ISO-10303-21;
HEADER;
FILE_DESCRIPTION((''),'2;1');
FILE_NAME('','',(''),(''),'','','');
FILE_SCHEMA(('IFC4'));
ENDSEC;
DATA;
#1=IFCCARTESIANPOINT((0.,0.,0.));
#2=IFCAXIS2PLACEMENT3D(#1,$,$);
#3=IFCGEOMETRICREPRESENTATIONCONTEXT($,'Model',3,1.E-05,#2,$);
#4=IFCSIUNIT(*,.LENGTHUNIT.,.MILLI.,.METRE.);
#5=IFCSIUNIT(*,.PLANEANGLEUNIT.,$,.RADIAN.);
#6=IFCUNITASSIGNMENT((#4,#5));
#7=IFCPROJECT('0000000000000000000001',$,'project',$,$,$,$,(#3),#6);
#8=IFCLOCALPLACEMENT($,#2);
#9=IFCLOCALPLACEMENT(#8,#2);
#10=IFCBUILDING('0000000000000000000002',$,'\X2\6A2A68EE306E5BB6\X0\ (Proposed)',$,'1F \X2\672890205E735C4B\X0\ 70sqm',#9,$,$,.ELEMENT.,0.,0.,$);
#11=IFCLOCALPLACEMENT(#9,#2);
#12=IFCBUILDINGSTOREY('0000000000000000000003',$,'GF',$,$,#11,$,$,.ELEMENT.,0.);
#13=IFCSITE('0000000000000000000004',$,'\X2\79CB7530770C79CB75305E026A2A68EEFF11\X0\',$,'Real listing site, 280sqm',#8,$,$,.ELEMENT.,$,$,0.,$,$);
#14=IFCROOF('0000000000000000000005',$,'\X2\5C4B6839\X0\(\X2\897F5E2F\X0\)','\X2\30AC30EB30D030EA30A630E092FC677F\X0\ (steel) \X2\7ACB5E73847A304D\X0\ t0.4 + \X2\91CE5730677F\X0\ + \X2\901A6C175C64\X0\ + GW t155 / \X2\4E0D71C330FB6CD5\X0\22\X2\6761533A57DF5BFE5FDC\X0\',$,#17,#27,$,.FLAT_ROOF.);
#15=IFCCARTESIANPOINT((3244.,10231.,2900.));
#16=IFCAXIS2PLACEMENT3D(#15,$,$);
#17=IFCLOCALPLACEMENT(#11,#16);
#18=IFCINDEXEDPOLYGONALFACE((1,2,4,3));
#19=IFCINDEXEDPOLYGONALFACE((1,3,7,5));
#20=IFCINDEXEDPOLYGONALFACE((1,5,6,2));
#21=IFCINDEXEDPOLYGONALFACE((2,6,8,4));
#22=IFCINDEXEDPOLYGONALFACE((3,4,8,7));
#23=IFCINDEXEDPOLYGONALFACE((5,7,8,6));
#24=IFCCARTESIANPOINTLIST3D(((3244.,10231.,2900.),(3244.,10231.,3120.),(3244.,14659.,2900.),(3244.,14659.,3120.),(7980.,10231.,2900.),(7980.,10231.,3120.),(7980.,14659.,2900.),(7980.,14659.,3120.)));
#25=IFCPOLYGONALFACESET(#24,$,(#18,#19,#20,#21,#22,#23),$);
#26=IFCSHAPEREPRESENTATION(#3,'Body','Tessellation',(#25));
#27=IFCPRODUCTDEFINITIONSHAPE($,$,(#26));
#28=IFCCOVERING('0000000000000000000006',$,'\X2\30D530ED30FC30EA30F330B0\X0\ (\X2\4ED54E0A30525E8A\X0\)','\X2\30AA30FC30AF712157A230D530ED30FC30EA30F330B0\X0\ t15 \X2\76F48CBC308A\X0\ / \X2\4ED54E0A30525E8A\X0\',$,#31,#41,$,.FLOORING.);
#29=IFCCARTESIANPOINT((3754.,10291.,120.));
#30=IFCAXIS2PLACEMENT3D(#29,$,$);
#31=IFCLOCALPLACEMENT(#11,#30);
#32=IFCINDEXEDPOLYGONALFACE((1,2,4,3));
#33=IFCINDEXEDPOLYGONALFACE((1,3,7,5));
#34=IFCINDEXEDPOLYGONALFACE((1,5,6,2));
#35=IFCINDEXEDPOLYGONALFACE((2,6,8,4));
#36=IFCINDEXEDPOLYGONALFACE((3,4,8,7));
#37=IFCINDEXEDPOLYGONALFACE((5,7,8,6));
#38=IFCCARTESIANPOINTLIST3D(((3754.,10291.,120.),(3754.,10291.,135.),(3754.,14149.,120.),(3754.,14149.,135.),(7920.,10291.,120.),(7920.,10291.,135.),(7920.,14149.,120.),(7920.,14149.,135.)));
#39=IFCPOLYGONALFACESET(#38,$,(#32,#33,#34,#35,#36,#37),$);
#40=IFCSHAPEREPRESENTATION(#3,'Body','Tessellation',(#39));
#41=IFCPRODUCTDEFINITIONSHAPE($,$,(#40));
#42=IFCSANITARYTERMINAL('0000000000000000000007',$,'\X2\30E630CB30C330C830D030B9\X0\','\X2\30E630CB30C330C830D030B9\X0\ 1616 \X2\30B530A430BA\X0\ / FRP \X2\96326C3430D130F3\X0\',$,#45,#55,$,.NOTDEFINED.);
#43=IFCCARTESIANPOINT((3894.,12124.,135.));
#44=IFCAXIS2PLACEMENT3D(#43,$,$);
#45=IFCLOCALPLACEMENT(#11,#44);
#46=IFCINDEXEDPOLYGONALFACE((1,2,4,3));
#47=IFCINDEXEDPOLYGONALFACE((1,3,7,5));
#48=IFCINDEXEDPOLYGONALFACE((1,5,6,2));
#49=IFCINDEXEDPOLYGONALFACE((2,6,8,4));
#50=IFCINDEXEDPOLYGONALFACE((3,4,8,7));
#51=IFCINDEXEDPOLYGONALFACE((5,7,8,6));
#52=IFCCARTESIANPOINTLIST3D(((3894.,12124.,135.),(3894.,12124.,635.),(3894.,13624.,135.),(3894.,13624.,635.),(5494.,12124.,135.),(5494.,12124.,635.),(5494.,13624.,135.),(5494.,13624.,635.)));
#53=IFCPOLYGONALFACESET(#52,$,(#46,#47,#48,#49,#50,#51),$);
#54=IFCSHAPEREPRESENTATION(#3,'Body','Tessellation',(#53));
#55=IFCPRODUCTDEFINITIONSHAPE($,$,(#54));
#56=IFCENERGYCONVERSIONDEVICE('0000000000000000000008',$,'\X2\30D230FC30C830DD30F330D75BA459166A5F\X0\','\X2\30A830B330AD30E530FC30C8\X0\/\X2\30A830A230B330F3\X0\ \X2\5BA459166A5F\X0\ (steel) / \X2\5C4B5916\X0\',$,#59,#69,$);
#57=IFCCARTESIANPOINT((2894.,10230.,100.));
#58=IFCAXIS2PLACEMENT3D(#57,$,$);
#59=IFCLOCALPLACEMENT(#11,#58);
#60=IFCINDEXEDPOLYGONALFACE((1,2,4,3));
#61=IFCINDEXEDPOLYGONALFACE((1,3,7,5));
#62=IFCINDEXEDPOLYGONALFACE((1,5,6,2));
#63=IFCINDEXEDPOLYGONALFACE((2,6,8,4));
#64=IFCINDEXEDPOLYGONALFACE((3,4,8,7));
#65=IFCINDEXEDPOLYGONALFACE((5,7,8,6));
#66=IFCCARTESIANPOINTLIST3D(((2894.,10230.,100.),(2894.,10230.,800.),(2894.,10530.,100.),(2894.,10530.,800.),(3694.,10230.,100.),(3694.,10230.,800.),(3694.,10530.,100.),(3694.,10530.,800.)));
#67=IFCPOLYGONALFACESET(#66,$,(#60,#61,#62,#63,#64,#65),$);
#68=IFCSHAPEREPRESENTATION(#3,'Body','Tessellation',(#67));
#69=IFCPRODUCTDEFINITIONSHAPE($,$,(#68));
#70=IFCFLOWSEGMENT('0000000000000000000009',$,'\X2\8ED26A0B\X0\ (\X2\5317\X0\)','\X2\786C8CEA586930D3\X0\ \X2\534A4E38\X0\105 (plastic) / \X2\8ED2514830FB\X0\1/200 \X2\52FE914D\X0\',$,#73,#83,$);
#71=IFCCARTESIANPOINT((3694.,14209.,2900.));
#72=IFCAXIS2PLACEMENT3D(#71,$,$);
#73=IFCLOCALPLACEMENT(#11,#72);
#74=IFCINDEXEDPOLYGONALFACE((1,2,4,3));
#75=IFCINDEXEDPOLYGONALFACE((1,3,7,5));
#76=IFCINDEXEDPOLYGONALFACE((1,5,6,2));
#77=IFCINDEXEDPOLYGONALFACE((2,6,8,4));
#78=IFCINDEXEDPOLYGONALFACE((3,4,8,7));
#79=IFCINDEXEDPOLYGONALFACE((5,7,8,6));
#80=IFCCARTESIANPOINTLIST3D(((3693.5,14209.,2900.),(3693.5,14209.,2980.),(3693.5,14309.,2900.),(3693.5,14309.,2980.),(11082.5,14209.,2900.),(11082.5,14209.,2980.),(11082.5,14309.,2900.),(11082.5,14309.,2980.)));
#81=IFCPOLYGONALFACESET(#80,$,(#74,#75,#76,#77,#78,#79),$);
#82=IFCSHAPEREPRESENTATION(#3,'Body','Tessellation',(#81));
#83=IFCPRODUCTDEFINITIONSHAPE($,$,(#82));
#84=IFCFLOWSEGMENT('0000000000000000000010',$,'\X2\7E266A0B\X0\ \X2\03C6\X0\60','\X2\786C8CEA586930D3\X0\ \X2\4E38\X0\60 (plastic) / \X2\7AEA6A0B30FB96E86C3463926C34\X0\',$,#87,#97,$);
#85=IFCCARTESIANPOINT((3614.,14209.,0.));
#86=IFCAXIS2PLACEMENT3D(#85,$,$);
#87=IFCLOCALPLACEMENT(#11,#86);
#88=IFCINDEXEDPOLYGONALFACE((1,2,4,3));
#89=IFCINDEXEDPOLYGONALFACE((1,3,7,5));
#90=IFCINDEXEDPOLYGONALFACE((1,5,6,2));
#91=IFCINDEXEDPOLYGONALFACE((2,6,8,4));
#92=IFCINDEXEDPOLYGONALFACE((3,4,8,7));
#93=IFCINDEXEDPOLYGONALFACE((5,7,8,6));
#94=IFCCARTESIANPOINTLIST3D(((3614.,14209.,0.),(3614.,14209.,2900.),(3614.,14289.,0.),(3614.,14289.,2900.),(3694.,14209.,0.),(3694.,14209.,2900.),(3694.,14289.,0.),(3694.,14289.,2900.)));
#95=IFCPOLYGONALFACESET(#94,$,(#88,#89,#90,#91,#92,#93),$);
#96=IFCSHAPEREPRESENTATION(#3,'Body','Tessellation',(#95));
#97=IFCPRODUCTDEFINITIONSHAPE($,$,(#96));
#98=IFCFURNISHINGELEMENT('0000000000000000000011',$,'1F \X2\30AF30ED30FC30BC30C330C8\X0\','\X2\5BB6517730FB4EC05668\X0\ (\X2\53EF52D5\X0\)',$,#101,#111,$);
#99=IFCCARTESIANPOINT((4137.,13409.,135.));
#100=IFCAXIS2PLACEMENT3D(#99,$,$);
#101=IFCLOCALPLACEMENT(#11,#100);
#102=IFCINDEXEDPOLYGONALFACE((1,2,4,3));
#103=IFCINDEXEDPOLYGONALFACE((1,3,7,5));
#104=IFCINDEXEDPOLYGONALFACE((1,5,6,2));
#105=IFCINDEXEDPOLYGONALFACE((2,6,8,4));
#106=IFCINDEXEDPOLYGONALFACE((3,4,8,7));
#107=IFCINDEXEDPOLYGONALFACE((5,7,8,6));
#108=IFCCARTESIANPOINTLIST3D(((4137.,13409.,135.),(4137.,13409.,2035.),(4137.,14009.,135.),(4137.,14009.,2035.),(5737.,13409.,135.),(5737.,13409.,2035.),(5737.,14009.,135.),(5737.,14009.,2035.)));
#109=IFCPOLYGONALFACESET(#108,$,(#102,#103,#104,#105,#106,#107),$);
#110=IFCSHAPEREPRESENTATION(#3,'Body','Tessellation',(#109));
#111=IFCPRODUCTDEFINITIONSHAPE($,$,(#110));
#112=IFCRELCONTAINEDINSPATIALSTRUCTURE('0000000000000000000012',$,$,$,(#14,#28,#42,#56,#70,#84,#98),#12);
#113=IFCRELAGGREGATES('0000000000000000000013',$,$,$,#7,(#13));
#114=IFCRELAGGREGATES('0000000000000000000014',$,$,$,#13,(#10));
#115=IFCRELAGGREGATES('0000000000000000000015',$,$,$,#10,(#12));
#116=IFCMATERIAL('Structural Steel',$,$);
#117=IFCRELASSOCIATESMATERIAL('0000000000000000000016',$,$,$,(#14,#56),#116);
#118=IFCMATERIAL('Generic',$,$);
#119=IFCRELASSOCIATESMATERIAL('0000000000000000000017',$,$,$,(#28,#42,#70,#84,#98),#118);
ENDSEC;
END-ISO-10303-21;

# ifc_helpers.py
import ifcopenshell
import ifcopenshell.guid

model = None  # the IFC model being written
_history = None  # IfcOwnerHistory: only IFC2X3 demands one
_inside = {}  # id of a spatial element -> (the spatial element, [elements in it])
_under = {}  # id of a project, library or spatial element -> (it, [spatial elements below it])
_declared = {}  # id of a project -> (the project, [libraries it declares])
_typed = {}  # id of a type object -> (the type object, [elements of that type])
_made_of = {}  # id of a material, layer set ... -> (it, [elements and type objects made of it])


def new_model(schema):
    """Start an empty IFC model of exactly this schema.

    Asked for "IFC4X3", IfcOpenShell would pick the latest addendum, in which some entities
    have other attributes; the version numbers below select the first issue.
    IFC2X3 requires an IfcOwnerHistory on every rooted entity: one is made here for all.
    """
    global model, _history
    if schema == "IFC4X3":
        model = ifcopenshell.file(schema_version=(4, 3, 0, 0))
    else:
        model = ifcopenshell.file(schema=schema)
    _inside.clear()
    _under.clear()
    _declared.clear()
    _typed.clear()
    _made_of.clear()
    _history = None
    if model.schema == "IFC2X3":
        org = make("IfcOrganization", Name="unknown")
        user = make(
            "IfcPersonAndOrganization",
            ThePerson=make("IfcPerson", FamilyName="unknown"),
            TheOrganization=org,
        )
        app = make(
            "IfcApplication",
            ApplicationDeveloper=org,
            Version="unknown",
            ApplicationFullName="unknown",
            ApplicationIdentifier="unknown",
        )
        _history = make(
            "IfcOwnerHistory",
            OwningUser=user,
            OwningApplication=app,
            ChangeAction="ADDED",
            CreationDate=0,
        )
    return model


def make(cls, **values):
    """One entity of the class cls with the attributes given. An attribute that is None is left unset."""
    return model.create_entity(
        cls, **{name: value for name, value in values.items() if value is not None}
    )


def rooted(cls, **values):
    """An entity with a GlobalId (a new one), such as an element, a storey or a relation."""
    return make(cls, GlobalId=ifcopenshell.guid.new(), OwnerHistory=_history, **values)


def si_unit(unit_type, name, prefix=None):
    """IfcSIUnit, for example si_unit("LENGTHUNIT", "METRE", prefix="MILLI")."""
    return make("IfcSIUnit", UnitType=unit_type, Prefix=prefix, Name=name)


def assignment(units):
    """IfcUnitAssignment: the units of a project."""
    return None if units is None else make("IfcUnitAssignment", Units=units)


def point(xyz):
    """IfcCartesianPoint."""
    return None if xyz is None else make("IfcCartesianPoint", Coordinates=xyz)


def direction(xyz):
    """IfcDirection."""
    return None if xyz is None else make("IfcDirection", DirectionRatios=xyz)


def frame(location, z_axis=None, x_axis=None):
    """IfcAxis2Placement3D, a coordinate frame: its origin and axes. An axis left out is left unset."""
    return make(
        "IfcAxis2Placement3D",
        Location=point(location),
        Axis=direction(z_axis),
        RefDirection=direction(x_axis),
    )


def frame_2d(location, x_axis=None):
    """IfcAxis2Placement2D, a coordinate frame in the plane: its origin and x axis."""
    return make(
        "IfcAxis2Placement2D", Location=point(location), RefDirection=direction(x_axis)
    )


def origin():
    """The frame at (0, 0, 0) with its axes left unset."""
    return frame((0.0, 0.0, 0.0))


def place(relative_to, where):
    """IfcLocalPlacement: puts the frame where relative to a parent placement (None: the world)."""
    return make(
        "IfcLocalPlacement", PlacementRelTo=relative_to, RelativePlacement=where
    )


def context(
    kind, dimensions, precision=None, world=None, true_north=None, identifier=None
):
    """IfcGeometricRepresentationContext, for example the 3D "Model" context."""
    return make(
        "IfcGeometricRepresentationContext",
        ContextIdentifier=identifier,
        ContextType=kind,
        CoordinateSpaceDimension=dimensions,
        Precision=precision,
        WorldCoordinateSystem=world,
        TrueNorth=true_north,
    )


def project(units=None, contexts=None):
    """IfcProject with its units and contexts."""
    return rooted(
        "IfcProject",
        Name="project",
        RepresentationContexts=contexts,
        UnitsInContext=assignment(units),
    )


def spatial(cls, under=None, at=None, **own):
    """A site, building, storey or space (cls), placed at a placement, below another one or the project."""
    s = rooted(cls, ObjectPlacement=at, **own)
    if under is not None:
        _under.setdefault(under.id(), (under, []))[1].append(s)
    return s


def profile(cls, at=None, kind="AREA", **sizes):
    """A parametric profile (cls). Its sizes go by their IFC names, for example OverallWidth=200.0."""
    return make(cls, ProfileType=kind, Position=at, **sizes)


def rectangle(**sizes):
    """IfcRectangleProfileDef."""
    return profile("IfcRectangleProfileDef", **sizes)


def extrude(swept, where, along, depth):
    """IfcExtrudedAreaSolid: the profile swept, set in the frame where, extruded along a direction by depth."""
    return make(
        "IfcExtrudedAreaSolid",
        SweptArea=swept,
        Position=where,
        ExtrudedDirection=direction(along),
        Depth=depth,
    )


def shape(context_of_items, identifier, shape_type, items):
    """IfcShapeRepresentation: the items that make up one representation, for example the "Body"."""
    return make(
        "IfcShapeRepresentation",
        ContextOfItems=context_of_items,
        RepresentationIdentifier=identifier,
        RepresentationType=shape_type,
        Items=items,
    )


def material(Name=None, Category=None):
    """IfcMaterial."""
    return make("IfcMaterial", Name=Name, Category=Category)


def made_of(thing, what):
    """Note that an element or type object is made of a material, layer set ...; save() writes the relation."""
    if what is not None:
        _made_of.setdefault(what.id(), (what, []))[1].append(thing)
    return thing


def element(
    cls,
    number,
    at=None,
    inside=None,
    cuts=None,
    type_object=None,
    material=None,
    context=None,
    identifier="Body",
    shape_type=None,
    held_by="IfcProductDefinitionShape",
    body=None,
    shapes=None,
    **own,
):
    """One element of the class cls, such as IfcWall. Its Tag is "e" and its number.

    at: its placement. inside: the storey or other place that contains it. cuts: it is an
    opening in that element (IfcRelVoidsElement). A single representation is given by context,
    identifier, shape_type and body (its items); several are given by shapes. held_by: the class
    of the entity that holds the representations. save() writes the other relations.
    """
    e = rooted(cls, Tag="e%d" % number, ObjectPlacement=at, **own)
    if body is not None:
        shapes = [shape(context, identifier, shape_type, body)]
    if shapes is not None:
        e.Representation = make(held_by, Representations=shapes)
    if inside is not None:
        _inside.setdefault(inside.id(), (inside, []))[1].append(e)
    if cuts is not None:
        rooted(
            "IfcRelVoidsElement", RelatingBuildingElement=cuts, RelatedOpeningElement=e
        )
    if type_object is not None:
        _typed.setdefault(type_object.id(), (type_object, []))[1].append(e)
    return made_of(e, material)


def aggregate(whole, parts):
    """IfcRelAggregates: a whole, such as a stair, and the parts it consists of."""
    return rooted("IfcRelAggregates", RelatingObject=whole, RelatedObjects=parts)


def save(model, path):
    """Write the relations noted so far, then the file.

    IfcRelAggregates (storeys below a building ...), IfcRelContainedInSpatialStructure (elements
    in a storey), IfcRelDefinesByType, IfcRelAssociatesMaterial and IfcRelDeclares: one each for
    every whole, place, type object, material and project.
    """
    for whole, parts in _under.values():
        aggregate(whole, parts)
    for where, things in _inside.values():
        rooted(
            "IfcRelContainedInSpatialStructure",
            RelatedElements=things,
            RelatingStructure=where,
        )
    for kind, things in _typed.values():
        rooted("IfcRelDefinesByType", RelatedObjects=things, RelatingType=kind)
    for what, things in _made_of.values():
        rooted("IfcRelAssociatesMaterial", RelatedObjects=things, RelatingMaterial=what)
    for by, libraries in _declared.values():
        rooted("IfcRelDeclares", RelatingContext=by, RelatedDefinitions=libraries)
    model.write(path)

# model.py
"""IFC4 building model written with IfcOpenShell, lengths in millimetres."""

from ifc_helpers import new_model, si_unit, frame, frame_2d, origin, place, context, project, spatial, rectangle, extrude, material, element, save


model = new_model("IFC4")

# Units and contexts
model_context = context("Model", 3, precision=1e-05, world=origin())
ifc_project = project(units=[si_unit("LENGTHUNIT", "METRE", prefix="MILLI"), si_unit("PLANEANGLEUNIT", "RADIAN")], contexts=[model_context])

# Site, building, storey
site_placement = place(None, origin())
site = spatial("IfcSite", under=ifc_project, at=site_placement, Name="秋田県秋田市横森１", ObjectType="Real listing site, 280sqm", CompositionType="ELEMENT", RefElevation=0.0)
building_placement = place(site_placement, origin())
building = spatial("IfcBuilding", under=site, at=building_placement, Name="横森の家 (Proposed)", ObjectType="1F 木造平屋 70sqm", CompositionType="ELEMENT", ElevationOfRefHeight=0.0, ElevationOfTerrain=0.0)
storey_placement = place(building_placement, origin())
storey = spatial("IfcBuildingStorey", under=building, at=storey_placement, Name="GF", CompositionType="ELEMENT", Elevation=0.0)

# Roof
ifc_material_1 = material(Name="Structural Steel")
roof_placement = place(storey_placement, frame((3244.0, 10231.0, 2900.0)))
element("IfcRoof", 1, at=roof_placement, inside=storey, material=ifc_material_1, Name="屋根(西帯)", Description="ガルバリウム鋼板 (steel) 立平葺き t0.4 + 野地板 + 通気層 + GW t155 / 不燃・法22条区域対応", PredefinedType="FLAT_ROOF", context=model_context, shape_type="SweptSolid", body=[
    extrude(rectangle(XDim=4736.0, YDim=4428.0, at=frame_2d((2368.0, 2214.0))), frame((3244.0, 10231.0, 2900.0)), (0.0, 0.0, 1.0), 220.0),
])

# Covering
ifc_material_2 = material(Name="Generic")
covering_placement = place(storey_placement, frame((3754.0, 10291.0, 120.0)))
element("IfcCovering", 2, at=covering_placement, inside=storey, material=ifc_material_2, Name="フローリング (仕上げ床)", Description="オーク無垢フローリング t15 直貼り / 仕上げ床", PredefinedType="FLOORING", context=model_context, shape_type="SweptSolid", body=[
    extrude(rectangle(XDim=4166.0, YDim=3858.0, at=frame_2d((2083.0, 1929.0))), frame((3754.0, 10291.0, 120.0)), (0.0, 0.0, 1.0), 15.0),
])

# Sanitary terminal
sanitary_terminal_placement = place(storey_placement, frame((3894.0, 12124.0, 135.0)))
element("IfcSanitaryTerminal", 3, at=sanitary_terminal_placement, inside=storey, material=ifc_material_2, Name="ユニットバス", Description="ユニットバス 1616 サイズ / FRP 防水パン", PredefinedType="NOTDEFINED", context=model_context, shape_type="SweptSolid", body=[
    extrude(rectangle(XDim=1600.0, YDim=1500.0, at=frame_2d((800.0, 750.0))), frame((3894.0, 12124.0, 135.0)), (0.0, 0.0, 1.0), 500.0),
])

# Energy conversion device
energy_conversion_device_placement = place(storey_placement, frame((2894.0, 10230.0, 100.0)))
element("IfcEnergyConversionDevice", 4, at=energy_conversion_device_placement, inside=storey, material=ifc_material_1, Name="ヒートポンプ室外機", Description="エコキュート/エアコン 室外機 (steel) / 屋外", context=model_context, shape_type="SweptSolid", body=[
    extrude(rectangle(XDim=800.0, YDim=300.0, at=frame_2d((400.0, 150.0))), frame((2894.0, 10230.0, 100.0)), (0.0, 0.0, 1.0), 700.0),
])

# Flow segments
flow_segment_1_placement = place(storey_placement, frame((3694.0, 14209.0, 2900.0)))
element("IfcFlowSegment", 5, at=flow_segment_1_placement, inside=storey, material=ifc_material_2, Name="軒樋 (北)", Description="硬質塩ビ 半丸105 (plastic) / 軒先・1/200 勾配", context=model_context, shape_type="SweptSolid", body=[
    extrude(rectangle(XDim=7389.0, YDim=100.0, at=frame_2d((3694.0, 50.0))), frame((3694.0, 14209.0, 2900.0)), (0.0, 0.0, 1.0), 80.0),
])
flow_segment_2_placement = place(storey_placement, frame((3614.0, 14209.0, 0.0)))
element("IfcFlowSegment", 6, at=flow_segment_2_placement, inside=storey, material=ifc_material_2, Name="縦樋 φ60", Description="硬質塩ビ 丸60 (plastic) / 竪樋・雨水排水", context=model_context, shape_type="SweptSolid", body=[
    extrude(rectangle(XDim=80.0, YDim=80.0, at=frame_2d((40.0, 40.0))), frame((3614.0, 14209.0, 0.0)), (0.0, 0.0, 1.0), 2900.0),
])

# Furnishing element
furnishing_placement = place(storey_placement, frame((4137.0, 13409.0, 135.0)))
element("IfcFurnishingElement", 7, at=furnishing_placement, inside=storey, material=ifc_material_2, Name="1F クローゼット", Description="家具・什器 (可動)", context=model_context, shape_type="SweptSolid", body=[
    extrude(rectangle(XDim=1600.0, YDim=600.0, at=frame_2d((800.0, 300.0))), frame((4137.0, 13409.0, 135.0)), (0.0, 0.0, 1.0), 1900.0),
])

save(model, "model.ifc")
